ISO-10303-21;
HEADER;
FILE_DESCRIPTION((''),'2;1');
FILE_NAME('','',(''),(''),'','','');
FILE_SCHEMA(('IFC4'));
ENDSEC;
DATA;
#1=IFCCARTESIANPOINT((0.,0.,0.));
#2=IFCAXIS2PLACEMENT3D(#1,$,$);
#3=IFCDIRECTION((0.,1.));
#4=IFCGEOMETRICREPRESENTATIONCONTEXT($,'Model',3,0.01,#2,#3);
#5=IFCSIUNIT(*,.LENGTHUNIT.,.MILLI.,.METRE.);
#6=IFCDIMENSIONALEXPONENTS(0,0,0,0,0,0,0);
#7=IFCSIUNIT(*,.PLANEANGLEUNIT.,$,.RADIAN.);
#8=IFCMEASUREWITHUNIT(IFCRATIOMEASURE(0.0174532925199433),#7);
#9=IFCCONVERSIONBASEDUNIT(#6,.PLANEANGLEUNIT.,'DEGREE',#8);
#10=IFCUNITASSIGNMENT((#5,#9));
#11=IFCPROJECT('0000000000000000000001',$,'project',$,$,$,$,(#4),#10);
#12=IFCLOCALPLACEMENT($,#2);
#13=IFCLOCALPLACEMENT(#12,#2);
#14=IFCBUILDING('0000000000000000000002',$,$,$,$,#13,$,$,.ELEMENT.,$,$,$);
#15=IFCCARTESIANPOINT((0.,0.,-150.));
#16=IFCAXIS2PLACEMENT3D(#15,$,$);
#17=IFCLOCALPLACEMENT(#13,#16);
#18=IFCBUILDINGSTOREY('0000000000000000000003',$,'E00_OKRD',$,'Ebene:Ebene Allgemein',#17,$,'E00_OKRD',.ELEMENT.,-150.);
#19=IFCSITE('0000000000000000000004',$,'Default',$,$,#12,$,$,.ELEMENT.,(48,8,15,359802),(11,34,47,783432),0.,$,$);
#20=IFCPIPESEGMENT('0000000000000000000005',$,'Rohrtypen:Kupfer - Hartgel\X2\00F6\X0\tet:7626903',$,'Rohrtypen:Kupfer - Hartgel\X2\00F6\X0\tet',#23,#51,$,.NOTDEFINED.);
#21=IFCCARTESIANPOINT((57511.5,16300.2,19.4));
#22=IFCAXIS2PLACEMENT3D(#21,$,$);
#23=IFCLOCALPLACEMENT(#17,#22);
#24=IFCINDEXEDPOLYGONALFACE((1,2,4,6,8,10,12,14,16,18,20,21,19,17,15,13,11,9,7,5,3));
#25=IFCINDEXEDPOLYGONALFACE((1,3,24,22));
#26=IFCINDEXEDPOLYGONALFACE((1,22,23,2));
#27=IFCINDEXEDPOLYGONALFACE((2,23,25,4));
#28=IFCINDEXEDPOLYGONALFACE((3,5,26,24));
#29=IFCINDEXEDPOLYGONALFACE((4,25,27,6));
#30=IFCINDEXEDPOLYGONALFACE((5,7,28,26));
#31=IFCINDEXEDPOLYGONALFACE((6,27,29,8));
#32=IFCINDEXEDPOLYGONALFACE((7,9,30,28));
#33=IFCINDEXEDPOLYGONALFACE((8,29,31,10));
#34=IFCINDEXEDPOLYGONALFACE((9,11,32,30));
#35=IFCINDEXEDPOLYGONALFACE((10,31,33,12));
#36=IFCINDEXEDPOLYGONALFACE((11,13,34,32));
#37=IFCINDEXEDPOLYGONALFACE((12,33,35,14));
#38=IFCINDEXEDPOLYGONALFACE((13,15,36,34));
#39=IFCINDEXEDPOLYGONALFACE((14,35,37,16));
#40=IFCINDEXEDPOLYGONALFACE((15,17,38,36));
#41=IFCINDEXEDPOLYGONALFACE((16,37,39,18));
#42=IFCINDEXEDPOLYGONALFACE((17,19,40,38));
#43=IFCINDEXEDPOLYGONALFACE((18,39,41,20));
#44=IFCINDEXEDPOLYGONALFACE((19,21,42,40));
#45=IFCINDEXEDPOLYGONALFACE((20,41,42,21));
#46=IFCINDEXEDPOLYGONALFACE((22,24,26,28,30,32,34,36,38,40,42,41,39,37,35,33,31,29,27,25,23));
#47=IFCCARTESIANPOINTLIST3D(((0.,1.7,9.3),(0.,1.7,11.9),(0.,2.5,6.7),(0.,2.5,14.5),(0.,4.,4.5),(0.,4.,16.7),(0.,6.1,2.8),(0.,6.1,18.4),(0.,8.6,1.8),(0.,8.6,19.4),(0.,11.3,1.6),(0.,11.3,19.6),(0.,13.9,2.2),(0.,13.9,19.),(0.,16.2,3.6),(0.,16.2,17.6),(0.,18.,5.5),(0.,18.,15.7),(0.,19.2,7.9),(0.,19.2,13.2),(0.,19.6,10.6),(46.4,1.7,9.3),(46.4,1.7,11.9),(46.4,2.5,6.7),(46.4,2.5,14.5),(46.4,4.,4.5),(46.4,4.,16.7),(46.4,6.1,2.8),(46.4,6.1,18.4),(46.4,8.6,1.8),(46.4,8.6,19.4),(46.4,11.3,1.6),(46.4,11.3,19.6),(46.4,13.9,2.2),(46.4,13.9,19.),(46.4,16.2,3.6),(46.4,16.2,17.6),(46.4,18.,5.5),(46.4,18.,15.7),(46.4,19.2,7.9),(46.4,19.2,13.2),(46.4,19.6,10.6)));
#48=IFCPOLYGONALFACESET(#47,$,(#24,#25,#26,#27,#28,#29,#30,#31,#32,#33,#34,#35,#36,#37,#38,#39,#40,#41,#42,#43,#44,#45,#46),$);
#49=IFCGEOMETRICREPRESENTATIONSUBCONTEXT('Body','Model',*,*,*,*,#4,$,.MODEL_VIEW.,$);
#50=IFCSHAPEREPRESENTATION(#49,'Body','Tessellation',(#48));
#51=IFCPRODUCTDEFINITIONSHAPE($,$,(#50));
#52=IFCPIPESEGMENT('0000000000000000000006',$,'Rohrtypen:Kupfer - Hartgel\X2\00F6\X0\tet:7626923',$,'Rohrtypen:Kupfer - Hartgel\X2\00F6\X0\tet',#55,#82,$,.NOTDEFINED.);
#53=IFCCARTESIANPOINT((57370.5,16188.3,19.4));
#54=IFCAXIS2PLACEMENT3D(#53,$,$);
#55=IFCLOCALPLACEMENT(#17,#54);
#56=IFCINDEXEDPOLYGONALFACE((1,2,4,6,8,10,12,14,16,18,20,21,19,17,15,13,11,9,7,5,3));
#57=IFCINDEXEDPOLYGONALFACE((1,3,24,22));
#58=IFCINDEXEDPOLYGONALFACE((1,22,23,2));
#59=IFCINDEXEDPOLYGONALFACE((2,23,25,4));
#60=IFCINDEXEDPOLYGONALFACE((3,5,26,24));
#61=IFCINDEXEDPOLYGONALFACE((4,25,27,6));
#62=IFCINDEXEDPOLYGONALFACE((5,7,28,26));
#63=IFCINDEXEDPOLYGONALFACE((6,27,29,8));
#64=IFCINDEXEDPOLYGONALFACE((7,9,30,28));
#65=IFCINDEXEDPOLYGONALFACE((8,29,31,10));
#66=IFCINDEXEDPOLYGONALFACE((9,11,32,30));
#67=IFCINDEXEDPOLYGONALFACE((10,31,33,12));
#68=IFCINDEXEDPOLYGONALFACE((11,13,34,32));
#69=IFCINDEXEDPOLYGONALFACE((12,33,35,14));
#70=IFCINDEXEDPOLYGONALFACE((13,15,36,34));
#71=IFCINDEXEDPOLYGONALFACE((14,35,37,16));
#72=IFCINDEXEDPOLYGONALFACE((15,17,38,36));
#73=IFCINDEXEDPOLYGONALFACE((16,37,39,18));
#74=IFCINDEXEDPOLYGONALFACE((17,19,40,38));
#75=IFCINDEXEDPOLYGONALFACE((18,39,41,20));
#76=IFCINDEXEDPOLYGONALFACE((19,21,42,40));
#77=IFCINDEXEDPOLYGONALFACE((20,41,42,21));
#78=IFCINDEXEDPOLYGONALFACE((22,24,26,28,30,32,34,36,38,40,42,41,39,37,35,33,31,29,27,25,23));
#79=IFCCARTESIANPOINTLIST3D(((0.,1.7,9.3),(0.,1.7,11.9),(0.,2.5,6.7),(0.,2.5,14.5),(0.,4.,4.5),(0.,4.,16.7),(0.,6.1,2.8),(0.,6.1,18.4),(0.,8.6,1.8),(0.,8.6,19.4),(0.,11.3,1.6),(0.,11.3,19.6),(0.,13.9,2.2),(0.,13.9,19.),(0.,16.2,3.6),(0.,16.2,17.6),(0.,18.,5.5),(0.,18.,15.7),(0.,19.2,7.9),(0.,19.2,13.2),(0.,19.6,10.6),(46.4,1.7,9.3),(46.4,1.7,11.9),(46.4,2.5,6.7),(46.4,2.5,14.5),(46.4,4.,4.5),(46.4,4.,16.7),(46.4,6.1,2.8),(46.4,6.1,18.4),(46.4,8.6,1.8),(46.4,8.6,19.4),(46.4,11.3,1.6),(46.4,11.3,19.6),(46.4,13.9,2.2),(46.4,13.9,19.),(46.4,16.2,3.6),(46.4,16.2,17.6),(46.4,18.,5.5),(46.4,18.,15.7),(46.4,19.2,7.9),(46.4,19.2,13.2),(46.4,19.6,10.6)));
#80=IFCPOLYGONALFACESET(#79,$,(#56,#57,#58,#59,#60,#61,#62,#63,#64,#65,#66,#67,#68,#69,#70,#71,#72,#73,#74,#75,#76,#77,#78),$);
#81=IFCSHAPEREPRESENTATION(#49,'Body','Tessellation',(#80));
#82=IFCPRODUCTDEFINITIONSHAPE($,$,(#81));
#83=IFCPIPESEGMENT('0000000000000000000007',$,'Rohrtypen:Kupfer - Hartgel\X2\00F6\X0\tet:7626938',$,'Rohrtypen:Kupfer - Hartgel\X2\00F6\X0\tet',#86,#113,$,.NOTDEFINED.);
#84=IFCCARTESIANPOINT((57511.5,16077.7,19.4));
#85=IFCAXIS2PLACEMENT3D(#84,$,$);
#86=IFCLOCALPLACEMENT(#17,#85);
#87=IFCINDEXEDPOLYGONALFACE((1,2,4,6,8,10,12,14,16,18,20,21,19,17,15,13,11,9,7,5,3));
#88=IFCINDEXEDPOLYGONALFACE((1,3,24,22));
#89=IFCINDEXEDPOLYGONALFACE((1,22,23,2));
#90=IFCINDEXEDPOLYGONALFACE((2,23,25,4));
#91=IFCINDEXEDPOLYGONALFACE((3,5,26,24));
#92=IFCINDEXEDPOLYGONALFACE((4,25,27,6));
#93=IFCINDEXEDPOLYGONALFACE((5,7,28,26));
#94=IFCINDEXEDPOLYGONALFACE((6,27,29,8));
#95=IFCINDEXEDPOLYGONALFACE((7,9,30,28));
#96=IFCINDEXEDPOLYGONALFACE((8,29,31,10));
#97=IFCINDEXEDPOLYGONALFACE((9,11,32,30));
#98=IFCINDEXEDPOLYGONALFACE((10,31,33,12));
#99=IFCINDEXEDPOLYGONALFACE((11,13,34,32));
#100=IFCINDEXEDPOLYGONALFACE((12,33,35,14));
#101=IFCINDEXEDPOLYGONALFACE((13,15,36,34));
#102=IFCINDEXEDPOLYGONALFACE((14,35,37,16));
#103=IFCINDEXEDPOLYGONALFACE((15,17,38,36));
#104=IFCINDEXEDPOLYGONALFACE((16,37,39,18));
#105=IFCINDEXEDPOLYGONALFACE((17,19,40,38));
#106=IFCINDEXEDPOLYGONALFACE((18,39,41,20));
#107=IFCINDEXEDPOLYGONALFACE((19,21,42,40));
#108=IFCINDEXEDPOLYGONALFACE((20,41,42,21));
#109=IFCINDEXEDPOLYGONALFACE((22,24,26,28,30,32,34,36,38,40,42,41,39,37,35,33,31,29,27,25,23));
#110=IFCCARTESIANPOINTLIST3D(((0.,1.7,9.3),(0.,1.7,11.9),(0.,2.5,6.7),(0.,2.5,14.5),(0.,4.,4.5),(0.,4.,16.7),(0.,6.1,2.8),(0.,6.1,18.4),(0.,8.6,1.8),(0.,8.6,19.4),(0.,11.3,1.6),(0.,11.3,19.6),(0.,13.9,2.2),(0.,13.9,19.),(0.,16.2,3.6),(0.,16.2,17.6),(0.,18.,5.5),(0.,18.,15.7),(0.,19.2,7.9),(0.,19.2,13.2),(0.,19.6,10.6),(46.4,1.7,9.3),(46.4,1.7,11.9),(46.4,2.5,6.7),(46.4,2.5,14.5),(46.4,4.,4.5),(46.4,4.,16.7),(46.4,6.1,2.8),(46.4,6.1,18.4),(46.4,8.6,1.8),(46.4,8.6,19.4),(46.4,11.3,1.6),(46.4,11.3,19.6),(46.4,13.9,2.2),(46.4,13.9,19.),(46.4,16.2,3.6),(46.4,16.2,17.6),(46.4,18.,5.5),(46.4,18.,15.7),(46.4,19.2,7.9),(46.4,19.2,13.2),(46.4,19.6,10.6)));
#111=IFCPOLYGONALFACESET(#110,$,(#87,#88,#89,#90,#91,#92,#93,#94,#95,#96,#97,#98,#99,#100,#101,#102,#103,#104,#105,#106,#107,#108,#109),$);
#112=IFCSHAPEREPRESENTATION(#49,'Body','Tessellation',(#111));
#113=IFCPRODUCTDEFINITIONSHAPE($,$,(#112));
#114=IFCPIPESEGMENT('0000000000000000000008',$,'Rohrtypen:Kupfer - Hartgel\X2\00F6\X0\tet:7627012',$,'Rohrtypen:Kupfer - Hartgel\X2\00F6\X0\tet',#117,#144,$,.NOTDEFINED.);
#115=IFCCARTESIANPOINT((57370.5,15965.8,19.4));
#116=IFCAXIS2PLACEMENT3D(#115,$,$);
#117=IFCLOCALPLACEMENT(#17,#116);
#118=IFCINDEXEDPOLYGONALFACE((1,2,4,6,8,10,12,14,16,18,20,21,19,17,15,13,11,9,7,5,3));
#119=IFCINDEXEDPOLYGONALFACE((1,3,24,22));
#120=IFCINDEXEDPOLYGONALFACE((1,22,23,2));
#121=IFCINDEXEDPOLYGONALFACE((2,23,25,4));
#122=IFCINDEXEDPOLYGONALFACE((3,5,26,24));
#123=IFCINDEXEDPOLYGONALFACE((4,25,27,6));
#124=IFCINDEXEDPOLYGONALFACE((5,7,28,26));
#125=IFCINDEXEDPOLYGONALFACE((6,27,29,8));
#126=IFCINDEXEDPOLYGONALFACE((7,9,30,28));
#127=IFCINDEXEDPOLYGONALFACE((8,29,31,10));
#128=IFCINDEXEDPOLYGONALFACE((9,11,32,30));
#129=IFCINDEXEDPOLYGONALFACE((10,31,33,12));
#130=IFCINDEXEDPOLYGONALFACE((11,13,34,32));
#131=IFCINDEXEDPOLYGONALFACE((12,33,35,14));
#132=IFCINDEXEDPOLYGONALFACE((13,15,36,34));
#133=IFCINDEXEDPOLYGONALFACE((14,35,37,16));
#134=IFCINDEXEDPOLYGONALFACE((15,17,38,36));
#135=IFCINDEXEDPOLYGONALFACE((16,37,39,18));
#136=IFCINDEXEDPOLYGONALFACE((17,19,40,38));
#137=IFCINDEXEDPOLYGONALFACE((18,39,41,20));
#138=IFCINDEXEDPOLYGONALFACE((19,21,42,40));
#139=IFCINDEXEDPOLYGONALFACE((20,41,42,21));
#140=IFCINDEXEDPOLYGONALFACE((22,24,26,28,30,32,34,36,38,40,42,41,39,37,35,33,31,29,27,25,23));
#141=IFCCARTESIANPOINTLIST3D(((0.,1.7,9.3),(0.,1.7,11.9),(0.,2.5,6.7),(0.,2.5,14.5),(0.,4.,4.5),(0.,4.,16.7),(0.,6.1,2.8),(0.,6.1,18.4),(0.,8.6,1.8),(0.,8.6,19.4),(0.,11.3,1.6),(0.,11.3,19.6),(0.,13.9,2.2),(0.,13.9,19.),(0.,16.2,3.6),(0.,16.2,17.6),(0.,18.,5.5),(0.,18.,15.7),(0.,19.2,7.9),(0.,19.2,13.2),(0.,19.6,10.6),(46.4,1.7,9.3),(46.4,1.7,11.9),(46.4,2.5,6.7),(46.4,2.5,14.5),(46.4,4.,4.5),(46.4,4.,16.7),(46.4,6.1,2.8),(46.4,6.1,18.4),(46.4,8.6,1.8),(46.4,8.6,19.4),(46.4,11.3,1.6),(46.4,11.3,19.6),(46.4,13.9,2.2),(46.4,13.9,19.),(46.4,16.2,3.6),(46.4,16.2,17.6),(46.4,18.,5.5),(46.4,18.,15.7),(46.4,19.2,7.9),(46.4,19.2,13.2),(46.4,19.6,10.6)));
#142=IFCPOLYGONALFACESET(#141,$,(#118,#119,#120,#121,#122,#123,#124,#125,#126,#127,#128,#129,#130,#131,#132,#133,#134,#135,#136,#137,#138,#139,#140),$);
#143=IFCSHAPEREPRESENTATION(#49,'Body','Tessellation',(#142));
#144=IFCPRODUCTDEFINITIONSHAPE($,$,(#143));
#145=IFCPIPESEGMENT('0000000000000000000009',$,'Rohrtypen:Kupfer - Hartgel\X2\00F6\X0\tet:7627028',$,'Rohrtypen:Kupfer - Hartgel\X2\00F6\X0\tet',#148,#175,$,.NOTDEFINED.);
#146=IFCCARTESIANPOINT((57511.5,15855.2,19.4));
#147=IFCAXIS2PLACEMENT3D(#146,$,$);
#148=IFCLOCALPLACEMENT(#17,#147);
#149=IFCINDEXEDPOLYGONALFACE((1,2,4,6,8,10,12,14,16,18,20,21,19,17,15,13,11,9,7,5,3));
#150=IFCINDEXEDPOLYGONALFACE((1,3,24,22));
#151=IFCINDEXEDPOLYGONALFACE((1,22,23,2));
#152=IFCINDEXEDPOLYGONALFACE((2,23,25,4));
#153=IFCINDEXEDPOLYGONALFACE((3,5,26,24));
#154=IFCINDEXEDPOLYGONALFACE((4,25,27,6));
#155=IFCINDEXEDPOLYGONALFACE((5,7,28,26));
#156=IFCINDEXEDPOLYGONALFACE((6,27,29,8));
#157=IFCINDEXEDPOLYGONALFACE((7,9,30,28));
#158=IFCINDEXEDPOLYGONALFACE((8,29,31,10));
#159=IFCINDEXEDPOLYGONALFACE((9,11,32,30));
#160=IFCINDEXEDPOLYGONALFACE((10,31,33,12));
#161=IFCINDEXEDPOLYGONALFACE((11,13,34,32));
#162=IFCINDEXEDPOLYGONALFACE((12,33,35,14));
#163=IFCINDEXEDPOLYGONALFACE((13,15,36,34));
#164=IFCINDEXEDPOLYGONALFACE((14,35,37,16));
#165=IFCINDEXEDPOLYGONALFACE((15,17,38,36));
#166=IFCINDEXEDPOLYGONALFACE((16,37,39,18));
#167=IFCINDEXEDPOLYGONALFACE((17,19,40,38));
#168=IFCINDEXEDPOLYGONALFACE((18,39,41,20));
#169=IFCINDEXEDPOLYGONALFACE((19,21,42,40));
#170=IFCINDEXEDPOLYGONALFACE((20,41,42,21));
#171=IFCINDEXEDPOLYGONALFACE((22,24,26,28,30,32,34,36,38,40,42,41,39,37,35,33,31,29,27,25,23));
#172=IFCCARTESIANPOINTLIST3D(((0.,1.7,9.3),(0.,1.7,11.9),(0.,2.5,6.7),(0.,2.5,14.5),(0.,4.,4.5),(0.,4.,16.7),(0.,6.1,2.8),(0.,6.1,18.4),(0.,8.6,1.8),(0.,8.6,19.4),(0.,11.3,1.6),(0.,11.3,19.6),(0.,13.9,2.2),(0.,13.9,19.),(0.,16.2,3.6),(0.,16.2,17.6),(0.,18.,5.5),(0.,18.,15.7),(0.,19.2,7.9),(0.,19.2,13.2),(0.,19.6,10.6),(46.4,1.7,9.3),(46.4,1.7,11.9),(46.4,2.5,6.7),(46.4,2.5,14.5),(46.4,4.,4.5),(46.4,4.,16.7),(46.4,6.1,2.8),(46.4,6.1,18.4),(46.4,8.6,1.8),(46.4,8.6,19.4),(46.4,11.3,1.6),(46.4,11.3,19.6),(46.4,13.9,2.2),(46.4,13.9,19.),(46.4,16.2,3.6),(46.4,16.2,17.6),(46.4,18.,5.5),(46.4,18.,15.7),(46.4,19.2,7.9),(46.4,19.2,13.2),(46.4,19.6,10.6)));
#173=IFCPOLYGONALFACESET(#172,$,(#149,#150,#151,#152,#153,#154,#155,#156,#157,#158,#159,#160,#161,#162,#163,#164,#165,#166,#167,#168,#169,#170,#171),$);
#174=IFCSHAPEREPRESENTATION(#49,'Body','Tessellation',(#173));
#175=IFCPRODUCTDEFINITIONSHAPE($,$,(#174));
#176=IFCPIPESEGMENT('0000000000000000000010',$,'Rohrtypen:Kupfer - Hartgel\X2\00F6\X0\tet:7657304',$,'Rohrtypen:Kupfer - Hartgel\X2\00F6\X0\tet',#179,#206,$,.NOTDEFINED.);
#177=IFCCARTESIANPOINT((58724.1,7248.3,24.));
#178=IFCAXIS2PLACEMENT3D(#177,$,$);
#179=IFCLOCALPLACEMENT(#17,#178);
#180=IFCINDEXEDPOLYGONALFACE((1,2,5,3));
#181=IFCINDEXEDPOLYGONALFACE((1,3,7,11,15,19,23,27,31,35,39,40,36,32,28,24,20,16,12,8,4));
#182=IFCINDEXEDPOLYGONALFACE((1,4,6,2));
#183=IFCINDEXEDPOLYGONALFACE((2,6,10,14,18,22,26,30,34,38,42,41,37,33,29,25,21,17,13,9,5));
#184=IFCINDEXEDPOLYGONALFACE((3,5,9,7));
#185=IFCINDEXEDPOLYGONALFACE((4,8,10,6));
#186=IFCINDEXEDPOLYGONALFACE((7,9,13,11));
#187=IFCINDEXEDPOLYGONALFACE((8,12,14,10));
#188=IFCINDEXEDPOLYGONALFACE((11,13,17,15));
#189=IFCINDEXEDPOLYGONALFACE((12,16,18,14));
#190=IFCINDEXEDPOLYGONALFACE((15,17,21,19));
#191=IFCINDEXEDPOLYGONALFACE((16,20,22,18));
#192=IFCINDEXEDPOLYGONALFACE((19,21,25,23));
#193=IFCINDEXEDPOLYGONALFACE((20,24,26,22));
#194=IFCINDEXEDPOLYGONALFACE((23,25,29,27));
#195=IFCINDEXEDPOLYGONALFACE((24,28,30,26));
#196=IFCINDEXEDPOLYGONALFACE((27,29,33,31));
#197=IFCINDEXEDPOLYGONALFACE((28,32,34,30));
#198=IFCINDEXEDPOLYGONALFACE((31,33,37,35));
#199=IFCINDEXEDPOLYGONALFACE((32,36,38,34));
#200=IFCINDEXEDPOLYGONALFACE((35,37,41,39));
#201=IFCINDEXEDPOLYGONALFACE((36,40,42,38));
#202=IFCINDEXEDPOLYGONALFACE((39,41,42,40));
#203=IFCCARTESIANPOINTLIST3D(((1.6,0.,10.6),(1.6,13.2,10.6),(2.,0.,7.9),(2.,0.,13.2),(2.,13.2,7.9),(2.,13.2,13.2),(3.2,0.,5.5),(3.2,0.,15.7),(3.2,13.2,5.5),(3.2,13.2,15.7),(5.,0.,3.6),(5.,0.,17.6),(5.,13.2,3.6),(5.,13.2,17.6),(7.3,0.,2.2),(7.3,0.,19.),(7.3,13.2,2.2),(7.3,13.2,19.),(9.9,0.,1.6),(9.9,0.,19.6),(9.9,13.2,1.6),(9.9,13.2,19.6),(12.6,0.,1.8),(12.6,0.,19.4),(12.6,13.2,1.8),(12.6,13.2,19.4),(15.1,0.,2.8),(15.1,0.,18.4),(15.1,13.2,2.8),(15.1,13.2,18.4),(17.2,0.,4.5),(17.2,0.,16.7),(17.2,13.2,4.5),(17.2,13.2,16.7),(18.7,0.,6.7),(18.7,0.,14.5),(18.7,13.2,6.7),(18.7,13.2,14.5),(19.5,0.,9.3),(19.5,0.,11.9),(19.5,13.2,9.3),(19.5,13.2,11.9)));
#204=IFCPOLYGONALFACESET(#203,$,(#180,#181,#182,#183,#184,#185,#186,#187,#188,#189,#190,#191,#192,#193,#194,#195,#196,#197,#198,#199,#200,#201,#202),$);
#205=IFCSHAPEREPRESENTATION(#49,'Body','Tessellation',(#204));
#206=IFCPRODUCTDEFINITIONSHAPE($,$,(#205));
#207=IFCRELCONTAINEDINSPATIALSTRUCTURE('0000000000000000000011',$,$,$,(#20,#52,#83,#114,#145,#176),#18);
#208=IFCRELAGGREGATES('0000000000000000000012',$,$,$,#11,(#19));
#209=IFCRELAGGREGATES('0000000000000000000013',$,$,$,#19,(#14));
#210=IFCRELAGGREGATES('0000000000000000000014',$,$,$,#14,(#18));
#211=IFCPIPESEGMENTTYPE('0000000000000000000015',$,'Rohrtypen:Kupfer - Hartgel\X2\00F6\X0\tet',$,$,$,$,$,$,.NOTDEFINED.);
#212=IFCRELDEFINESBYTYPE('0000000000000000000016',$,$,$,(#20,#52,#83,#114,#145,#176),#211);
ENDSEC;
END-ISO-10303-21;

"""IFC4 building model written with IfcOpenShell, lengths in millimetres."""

from ifc_helpers import new_model, entity, si_unit, converted_unit, direction, frame, frame_2d, origin, origin_2d_with_axis, place, context, subcontext, project, spatial, circle, extrude, type_object, element, save


model = new_model("IFC4")

# Units and contexts
model_context = context("Model", 3, precision=0.01, world=origin(), true_north=direction((0.0, 1.0)))
body_context = subcontext(model_context, "Body", "Model", "MODEL_VIEW")
ifc_project = project(units=[si_unit("LENGTHUNIT", "METRE", prefix="MILLI"), converted_unit("PLANEANGLEUNIT", "DEGREE", entity("IfcRatioMeasure", 0.0174532925199433), si_unit("PLANEANGLEUNIT", "RADIAN"), dimensions=[0, 0, 0, 0, 0, 0, 0])], contexts=[model_context])

# Site, building, storey
site_placement = place(None, origin())
site = spatial("IfcSite", under=ifc_project, at=site_placement, Name="Default", CompositionType="ELEMENT", RefLatitude=(48, 8, 15, 359802), RefLongitude=(11, 34, 47, 783432), RefElevation=0.0)
building_placement = place(site_placement, origin())
building = spatial("IfcBuilding", under=site, at=building_placement, CompositionType="ELEMENT")
storey_placement = place(building_placement, frame((0.0, 0.0, -150.0)))
storey = spatial("IfcBuildingStorey", under=building, at=storey_placement, Name="E00_OKRD", ObjectType="Ebene:Ebene Allgemein", LongName="E00_OKRD", CompositionType="ELEMENT", Elevation=-150.0)

# Pipe segments
pipe_segment_type = type_object("IfcPipeSegmentType", Name="Rohrtypen:Kupfer - Hartgelötet", PredefinedType="NOTDEFINED")
pipe_segment_1_placement = place(storey_placement, frame((57511.5, 16300.2, 19.4)))
element("IfcPipeSegment", 1, at=pipe_segment_1_placement, inside=storey, type_object=pipe_segment_type, Name="Rohrtypen:Kupfer - Hartgelötet:7626903", ObjectType="Rohrtypen:Kupfer - Hartgelötet", PredefinedType="NOTDEFINED", context=body_context, shape_type="SweptSolid", body=[
    extrude(circle(Radius=9.0, at=frame_2d((0.0, 0.0), x_axis=(1.0, 0.0))), frame((0.0, 10.6, 10.6), z_axis=(1.0, 0.0, 0.0), x_axis=(0.0, 1.0, 0.0)), (0.0, 0.0, 1.0), 46.4),
])
pipe_segment_2_placement = place(storey_placement, frame((57370.5, 16188.3, 19.4)))
element("IfcPipeSegment", 2, at=pipe_segment_2_placement, inside=storey, type_object=pipe_segment_type, Name="Rohrtypen:Kupfer - Hartgelötet:7626923", ObjectType="Rohrtypen:Kupfer - Hartgelötet", PredefinedType="NOTDEFINED", context=body_context, shape_type="SweptSolid", body=[
    extrude(circle(Radius=9.0, at=frame_2d((0.0, 0.0), x_axis=(1.0, 0.0))), frame((0.0, 10.6, 10.6), z_axis=(1.0, 0.0, 0.0), x_axis=(0.0, 1.0, 0.0)), (0.0, 0.0, 1.0), 46.4),
])
pipe_segment_3_placement = place(storey_placement, frame((57511.5, 16077.7, 19.4)))
element("IfcPipeSegment", 3, at=pipe_segment_3_placement, inside=storey, type_object=pipe_segment_type, Name="Rohrtypen:Kupfer - Hartgelötet:7626938", ObjectType="Rohrtypen:Kupfer - Hartgelötet", PredefinedType="NOTDEFINED", context=body_context, shape_type="SweptSolid", body=[
    extrude(circle(Radius=9.0, at=frame_2d((0.0, 0.0), x_axis=(1.0, 0.0))), frame((0.0, 10.6, 10.6), z_axis=(1.0, 0.0, 0.0), x_axis=(0.0, 1.0, 0.0)), (0.0, 0.0, 1.0), 46.4),
])
pipe_segment_4_placement = place(storey_placement, frame((57370.5, 15965.8, 19.4)))
element("IfcPipeSegment", 4, at=pipe_segment_4_placement, inside=storey, type_object=pipe_segment_type, Name="Rohrtypen:Kupfer - Hartgelötet:7627012", ObjectType="Rohrtypen:Kupfer - Hartgelötet", PredefinedType="NOTDEFINED", context=body_context, shape_type="SweptSolid", body=[
    extrude(circle(Radius=9.0, at=frame_2d((0.0, 0.0), x_axis=(1.0, 0.0))), frame((0.0, 10.6, 10.6), z_axis=(1.0, 0.0, 0.0), x_axis=(0.0, 1.0, 0.0)), (0.0, 0.0, 1.0), 46.4),
])
pipe_segment_5_placement = place(storey_placement, frame((57511.5, 15855.2, 19.4)))
element("IfcPipeSegment", 5, at=pipe_segment_5_placement, inside=storey, type_object=pipe_segment_type, Name="Rohrtypen:Kupfer - Hartgelötet:7627028", ObjectType="Rohrtypen:Kupfer - Hartgelötet", PredefinedType="NOTDEFINED", context=body_context, shape_type="SweptSolid", body=[
    extrude(circle(Radius=9.0, at=frame_2d((0.0, 0.0), x_axis=(1.0, 0.0))), frame((0.0, 10.6, 10.6), z_axis=(1.0, 0.0, 0.0), x_axis=(0.0, 1.0, 0.0)), (0.0, 0.0, 1.0), 46.4),
])
pipe_segment_6_placement = place(storey_placement, frame((58724.1, 7248.3, 24.0)))
element("IfcPipeSegment", 6, at=pipe_segment_6_placement, inside=storey, type_object=pipe_segment_type, Name="Rohrtypen:Kupfer - Hartgelötet:7657304", ObjectType="Rohrtypen:Kupfer - Hartgelötet", PredefinedType="NOTDEFINED", context=body_context, shape_type="SweptSolid", body=[
    extrude(circle(Radius=9.0, at=origin_2d_with_axis()), frame((10.6, 0.0, 10.6), z_axis=(0.0, 1.0, 0.0), x_axis=(-1.0, 0.0, 0.0)), (0.0, 0.0, 1.0), 13.2),
])

save(model, "model.ifc")
